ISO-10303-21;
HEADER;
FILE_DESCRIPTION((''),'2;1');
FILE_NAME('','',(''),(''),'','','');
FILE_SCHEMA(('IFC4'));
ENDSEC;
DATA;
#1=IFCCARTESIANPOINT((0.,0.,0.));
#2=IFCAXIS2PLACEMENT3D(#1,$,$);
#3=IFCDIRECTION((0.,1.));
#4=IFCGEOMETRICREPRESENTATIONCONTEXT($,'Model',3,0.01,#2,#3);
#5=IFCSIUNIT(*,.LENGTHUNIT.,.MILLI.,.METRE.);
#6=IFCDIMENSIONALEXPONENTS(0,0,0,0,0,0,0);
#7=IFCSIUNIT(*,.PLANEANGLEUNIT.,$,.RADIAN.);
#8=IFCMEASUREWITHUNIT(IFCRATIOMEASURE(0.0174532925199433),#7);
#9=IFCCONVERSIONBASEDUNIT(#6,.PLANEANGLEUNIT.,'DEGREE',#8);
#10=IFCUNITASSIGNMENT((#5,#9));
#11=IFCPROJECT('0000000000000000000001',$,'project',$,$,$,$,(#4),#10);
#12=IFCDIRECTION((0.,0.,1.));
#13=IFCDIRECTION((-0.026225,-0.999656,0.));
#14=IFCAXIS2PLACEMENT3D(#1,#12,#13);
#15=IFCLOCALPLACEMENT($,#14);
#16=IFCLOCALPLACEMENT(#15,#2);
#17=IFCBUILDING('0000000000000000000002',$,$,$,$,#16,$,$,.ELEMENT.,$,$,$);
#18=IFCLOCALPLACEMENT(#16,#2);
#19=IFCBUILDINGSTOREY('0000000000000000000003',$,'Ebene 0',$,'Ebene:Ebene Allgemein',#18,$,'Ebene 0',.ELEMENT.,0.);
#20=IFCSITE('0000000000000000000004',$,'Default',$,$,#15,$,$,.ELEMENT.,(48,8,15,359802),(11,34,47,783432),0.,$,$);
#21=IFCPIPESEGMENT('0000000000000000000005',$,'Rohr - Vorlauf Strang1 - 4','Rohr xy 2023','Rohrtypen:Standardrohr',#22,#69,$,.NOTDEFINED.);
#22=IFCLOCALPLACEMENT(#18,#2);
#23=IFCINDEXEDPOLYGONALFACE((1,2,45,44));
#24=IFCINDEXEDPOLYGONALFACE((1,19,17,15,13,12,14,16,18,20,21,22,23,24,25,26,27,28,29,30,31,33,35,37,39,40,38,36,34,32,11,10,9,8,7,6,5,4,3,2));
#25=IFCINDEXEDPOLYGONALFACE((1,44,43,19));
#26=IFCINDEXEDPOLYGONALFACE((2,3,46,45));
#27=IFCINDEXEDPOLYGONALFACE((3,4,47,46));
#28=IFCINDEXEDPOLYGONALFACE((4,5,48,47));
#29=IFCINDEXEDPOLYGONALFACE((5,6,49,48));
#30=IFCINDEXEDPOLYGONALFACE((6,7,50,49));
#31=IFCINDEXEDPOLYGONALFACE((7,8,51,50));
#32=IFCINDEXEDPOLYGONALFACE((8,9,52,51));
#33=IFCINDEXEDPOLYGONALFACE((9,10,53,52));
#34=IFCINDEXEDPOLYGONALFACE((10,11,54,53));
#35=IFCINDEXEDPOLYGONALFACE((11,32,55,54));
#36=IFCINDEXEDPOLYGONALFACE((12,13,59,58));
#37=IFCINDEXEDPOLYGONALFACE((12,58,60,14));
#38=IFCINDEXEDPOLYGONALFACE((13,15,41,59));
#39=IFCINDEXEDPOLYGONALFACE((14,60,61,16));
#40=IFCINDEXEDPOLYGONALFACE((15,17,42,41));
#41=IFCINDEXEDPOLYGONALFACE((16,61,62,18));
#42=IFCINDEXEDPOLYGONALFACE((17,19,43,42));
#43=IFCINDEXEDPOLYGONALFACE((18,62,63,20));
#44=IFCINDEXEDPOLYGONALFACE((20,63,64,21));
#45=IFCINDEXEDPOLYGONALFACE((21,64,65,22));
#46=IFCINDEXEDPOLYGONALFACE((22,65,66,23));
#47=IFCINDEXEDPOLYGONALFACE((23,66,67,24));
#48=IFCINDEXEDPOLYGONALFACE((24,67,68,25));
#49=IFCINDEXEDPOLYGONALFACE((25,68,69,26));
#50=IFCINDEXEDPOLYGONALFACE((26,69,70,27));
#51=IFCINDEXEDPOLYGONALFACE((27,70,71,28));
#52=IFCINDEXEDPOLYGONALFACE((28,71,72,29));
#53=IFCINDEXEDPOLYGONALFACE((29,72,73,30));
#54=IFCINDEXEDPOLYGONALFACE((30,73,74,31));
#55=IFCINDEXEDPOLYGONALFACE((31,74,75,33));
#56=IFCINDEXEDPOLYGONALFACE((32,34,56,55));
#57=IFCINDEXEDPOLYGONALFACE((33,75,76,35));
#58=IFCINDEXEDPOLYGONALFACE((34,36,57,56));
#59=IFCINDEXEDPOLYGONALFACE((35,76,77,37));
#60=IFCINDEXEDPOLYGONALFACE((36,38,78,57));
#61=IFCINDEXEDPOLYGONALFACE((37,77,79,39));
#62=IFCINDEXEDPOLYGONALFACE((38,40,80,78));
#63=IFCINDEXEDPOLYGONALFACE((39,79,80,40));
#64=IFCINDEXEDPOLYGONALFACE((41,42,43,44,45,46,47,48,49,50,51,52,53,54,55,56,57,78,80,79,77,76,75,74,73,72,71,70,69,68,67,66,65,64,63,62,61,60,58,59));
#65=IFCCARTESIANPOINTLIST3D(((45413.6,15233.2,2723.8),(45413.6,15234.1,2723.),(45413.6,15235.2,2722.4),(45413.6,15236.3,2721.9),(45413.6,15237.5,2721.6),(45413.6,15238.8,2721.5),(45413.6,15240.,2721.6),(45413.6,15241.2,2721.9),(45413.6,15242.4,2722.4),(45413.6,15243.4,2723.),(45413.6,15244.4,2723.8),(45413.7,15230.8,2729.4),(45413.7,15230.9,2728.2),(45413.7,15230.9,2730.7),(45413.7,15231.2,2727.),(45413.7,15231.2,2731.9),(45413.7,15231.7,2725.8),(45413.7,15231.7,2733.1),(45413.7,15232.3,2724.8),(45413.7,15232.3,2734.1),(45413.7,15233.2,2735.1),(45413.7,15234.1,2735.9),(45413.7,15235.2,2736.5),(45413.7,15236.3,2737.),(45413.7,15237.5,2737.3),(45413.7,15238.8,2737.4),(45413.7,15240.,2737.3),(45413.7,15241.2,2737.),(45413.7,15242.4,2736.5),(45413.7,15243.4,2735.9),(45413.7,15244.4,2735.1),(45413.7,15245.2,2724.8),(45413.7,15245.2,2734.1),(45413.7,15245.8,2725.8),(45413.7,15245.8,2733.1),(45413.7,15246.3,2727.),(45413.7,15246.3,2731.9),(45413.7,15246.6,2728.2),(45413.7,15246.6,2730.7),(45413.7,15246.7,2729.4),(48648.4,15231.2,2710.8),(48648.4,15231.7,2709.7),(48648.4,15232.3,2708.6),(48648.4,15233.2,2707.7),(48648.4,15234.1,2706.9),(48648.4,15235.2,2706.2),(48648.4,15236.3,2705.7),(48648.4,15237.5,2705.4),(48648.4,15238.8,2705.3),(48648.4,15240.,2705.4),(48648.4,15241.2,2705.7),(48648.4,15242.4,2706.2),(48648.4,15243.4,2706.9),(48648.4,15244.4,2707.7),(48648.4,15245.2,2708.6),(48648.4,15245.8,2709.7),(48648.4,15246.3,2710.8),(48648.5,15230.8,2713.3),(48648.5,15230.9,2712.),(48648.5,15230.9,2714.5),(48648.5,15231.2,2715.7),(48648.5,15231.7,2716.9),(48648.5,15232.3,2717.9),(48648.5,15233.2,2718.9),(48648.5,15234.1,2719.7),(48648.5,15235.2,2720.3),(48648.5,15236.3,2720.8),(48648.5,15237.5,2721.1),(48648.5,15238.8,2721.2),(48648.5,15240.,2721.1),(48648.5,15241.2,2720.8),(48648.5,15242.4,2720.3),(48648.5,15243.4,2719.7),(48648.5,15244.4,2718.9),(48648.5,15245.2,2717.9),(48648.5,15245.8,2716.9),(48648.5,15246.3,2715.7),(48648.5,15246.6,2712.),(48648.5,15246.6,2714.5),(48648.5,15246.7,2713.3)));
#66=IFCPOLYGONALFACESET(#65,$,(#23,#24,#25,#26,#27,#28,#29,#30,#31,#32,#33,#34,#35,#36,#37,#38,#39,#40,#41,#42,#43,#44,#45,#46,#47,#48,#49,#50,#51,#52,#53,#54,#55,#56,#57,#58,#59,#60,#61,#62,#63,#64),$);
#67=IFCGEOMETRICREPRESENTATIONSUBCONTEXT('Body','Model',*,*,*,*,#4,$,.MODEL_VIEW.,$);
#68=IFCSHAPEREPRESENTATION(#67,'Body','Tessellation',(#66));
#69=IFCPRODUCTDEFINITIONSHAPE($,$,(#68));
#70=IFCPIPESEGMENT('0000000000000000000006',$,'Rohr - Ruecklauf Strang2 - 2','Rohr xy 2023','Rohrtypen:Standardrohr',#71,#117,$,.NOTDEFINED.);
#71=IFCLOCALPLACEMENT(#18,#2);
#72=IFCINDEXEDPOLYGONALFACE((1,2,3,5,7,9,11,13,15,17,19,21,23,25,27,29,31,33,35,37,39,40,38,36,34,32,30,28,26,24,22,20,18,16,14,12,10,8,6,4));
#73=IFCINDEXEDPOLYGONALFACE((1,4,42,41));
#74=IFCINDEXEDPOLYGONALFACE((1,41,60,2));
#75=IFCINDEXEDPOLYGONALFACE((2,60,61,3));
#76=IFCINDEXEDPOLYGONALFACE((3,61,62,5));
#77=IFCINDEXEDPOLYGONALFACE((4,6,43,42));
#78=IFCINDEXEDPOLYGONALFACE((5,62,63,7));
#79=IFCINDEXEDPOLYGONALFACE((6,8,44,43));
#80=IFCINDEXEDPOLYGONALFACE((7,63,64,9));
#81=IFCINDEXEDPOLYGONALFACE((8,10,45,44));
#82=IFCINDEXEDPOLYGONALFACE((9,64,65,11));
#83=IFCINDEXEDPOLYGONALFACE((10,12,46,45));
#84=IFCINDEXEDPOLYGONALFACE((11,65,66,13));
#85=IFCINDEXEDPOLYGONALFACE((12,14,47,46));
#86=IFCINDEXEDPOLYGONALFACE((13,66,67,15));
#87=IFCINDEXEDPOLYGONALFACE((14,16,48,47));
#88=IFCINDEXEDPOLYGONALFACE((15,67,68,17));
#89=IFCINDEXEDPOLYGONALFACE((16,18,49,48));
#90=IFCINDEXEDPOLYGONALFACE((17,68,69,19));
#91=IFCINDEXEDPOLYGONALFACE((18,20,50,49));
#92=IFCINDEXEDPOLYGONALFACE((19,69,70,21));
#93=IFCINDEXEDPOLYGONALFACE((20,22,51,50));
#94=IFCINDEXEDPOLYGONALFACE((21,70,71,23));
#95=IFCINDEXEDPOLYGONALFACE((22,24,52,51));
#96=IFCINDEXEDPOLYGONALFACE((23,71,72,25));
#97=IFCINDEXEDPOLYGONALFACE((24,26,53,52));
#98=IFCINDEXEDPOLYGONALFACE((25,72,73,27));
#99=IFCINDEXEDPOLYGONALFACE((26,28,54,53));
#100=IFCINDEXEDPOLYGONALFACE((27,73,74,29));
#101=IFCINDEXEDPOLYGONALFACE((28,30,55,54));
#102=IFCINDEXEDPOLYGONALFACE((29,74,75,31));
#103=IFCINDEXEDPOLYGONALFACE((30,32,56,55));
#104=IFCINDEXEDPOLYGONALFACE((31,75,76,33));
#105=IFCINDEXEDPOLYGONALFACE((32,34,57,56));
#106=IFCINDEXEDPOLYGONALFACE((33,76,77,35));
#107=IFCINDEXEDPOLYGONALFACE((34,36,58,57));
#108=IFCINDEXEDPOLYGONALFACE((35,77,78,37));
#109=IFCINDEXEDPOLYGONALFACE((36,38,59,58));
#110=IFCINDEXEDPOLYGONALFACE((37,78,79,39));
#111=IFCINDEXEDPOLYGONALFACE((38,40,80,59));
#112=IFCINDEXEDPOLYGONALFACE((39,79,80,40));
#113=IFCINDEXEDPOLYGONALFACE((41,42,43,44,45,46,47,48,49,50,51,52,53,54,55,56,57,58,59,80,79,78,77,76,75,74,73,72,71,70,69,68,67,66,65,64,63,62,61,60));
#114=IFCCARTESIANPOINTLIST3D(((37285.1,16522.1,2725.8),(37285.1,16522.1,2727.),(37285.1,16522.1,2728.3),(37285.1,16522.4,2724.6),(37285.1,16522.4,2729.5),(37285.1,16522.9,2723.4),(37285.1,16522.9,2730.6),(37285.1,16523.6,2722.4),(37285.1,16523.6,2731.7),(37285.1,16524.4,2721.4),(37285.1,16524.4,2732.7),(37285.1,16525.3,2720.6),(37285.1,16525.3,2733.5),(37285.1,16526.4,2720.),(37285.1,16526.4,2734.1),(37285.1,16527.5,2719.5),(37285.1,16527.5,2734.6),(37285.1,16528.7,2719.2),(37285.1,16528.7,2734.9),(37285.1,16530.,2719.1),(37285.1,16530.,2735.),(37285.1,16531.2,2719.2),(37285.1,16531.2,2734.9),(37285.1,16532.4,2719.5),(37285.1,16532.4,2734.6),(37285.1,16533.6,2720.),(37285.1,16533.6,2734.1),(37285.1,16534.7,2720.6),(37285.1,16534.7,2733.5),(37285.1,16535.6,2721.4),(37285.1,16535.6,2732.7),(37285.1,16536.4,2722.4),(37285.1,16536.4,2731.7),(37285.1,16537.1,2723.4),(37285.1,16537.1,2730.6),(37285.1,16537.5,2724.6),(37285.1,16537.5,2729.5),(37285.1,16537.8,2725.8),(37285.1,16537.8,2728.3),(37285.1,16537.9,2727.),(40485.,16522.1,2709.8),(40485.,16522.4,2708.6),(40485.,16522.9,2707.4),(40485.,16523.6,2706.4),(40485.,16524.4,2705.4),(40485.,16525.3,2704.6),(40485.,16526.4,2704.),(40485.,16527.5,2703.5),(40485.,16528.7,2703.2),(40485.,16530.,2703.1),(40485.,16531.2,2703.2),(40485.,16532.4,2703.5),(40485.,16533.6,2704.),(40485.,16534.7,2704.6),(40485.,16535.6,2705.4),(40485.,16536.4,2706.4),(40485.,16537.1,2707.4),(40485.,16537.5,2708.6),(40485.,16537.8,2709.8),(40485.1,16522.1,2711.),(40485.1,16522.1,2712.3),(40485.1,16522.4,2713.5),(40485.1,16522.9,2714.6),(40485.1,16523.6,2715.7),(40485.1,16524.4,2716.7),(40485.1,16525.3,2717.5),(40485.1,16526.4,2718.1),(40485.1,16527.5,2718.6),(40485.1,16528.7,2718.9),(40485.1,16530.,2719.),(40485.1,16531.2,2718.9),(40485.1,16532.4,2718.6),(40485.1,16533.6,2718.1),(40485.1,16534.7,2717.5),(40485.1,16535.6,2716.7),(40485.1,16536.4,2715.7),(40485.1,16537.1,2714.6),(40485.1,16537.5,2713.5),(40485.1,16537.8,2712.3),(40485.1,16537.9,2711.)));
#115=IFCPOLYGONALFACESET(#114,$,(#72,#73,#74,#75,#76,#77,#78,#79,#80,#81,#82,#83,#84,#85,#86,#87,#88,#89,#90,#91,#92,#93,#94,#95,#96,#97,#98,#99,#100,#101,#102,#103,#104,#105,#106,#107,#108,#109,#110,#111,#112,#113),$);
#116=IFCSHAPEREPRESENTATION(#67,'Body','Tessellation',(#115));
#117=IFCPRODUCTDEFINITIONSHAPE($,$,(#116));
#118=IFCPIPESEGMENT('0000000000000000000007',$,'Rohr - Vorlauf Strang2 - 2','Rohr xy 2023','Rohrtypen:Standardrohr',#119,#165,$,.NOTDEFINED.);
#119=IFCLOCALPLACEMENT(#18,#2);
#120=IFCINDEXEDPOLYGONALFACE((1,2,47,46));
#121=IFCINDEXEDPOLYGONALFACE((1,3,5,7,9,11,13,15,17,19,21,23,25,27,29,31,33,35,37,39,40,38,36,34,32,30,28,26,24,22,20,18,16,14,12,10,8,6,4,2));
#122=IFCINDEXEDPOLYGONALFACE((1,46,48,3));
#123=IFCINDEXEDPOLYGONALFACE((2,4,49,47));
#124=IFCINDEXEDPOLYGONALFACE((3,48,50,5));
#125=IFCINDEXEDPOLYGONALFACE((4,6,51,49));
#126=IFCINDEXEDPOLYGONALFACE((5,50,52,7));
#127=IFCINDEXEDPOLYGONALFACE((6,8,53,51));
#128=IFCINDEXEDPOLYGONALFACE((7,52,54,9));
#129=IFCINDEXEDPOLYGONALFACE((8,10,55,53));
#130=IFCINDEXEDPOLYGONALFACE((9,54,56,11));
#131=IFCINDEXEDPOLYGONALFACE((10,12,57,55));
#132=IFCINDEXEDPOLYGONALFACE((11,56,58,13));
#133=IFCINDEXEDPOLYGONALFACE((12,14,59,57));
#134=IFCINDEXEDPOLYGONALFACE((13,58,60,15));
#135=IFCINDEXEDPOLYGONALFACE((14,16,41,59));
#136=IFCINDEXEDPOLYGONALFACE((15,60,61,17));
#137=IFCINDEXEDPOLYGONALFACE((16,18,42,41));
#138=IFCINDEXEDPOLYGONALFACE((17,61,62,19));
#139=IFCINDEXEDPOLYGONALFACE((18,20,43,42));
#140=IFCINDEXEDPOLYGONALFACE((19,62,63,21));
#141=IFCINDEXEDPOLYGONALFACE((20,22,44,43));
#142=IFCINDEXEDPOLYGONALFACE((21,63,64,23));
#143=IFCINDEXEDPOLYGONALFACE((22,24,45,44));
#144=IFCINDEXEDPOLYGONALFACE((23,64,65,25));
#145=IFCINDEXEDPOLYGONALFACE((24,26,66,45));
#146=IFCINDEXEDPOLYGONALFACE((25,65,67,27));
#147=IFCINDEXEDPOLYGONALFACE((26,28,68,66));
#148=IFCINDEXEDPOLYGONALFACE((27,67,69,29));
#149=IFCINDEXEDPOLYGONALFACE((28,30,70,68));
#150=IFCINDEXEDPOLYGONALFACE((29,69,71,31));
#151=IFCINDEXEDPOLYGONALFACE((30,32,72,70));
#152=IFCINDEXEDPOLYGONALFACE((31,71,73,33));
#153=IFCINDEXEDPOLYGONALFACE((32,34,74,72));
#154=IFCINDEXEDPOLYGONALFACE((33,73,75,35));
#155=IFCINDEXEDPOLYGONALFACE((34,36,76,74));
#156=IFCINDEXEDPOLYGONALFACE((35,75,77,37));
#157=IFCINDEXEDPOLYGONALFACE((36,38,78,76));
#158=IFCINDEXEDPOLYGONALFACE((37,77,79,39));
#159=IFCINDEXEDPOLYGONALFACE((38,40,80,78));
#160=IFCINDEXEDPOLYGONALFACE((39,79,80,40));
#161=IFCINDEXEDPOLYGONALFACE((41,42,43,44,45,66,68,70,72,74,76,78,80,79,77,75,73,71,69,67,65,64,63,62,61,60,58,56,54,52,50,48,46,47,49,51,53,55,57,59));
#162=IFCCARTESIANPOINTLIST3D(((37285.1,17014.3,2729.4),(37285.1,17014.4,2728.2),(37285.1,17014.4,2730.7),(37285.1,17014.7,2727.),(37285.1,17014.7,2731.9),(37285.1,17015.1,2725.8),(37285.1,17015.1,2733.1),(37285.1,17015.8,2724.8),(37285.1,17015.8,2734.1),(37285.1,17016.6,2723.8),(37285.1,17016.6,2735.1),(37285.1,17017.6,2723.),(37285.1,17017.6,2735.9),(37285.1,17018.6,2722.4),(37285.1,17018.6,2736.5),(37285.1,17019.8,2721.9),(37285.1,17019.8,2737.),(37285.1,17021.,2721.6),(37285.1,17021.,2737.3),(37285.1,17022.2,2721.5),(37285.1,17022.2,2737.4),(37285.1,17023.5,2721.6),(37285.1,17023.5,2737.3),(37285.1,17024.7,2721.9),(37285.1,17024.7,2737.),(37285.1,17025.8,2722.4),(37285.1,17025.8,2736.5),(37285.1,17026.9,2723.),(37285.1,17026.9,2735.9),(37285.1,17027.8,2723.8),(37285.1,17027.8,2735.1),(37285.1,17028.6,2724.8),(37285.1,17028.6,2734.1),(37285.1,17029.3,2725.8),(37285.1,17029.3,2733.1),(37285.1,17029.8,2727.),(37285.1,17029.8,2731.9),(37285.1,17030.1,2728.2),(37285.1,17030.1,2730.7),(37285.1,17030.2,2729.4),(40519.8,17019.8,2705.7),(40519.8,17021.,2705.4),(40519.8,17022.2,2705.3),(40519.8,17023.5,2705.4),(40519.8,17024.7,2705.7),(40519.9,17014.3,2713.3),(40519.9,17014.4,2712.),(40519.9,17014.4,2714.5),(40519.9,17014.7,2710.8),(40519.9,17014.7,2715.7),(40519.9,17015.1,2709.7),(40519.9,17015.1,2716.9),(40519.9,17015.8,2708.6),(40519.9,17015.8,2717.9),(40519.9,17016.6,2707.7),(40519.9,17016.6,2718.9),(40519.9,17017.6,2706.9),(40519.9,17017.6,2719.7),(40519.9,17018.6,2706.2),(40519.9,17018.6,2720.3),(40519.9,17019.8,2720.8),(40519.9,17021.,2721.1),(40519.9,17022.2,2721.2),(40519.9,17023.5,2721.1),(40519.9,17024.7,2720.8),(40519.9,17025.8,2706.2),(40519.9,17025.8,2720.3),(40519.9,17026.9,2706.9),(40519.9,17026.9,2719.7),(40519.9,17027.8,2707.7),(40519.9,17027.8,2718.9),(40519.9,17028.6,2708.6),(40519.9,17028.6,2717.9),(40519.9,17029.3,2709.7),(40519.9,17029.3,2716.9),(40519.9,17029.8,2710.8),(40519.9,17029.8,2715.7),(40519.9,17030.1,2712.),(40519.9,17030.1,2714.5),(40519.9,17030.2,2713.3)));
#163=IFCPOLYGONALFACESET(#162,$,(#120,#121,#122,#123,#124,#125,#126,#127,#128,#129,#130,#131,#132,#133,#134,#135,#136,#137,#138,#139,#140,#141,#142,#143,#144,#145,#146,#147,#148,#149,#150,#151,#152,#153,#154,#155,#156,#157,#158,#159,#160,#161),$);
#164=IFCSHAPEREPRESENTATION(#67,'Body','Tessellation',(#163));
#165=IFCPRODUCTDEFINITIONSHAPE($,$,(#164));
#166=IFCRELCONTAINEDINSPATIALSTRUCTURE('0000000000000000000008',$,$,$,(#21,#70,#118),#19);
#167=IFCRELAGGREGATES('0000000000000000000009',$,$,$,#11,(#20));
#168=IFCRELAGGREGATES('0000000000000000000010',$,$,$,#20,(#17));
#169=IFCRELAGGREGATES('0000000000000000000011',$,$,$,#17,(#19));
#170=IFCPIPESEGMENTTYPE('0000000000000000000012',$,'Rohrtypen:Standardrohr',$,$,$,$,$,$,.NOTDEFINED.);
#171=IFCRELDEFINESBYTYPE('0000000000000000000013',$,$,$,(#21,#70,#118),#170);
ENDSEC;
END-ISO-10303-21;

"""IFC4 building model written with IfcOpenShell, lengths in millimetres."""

from ifc_helpers import new_model, entity, si_unit, converted_unit, direction, frame, origin, place, context, subcontext, project, spatial, indexed_curve, outline, extrude, type_object, element, save


model = new_model("IFC4")

# Units and contexts
model_context = context("Model", 3, precision=0.01, world=origin(), true_north=direction((0.0, 1.0)))
body_context = subcontext(model_context, "Body", "Model", "MODEL_VIEW")
ifc_project = project(units=[si_unit("LENGTHUNIT", "METRE", prefix="MILLI"), converted_unit("PLANEANGLEUNIT", "DEGREE", entity("IfcRatioMeasure", 0.0174532925199433), si_unit("PLANEANGLEUNIT", "RADIAN"), dimensions=[0, 0, 0, 0, 0, 0, 0])], contexts=[model_context])

# Site, building, storey
site_placement = place(None, frame((0.0, 0.0, 0.0), z_axis=(0.0, 0.0, 1.0), x_axis=(-0.026225, -0.999656, 0.0)))
site = spatial("IfcSite", under=ifc_project, at=site_placement, Name="Default", CompositionType="ELEMENT", RefLatitude=(48, 8, 15, 359802), RefLongitude=(11, 34, 47, 783432), RefElevation=0.0)
building_placement = place(site_placement, origin())
building = spatial("IfcBuilding", under=site, at=building_placement, CompositionType="ELEMENT")
storey_placement = place(building_placement, origin())
storey = spatial("IfcBuildingStorey", under=building, at=storey_placement, Name="Ebene 0", ObjectType="Ebene:Ebene Allgemein", LongName="Ebene 0", CompositionType="ELEMENT", Elevation=0.0)

# Pipe segments
pipe_segment_type = type_object("IfcPipeSegmentType", Name="Rohrtypen:Standardrohr", PredefinedType="NOTDEFINED")
pipe_segment_1_placement = place(storey_placement, origin())
element("IfcPipeSegment", 1, at=pipe_segment_1_placement, inside=storey, type_object=pipe_segment_type, Name="Rohr - Vorlauf Strang1 - 4", Description="Rohr xy 2023", ObjectType="Rohrtypen:Standardrohr", PredefinedType="NOTDEFINED", context=body_context, shape_type="SweptSolid", body=[
    extrude(outline(indexed_curve([(7.9, 0.0), (7.8, 1.2), (7.6, 2.5), (7.1, 3.6), (6.4, 4.7), (5.6, 5.6), (4.7, 6.4), (3.6, 7.1), (2.5, 7.6), (1.2, 7.8), (0.0, 7.9), (-1.2, 7.8), (-2.5, 7.6), (-3.6, 7.1), (-4.7, 6.4), (-5.6, 5.6), (-6.4, 4.7), (-7.1, 3.6), (-7.6, 2.5), (-7.8, 1.2), (-7.9, 0.0), (-7.8, -1.2), (-7.6, -2.5), (-7.1, -3.6), (-6.4, -4.7), (-5.6, -5.6), (-4.7, -6.4), (-3.6, -7.1), (-2.5, -7.6), (-1.2, -7.8), (0.0, -7.9), (1.2, -7.8), (2.5, -7.6), (3.6, -7.1), (4.7, -6.4), (5.6, -5.6), (6.4, -4.7), (7.1, -3.6), (7.6, -2.5), (7.8, -1.2), (7.9, 0.0)], self_intersect=False)), frame((48648.5, 15238.8, 2713.3), z_axis=(-0.999988, 0.0, 0.005), x_axis=(0.0, 1.0, 0.0)), (0.0, 0.0, 1.0), 3234.8),
])
pipe_segment_2_placement = place(storey_placement, origin())
element("IfcPipeSegment", 2, at=pipe_segment_2_placement, inside=storey, type_object=pipe_segment_type, Name="Rohr - Ruecklauf Strang2 - 2", Description="Rohr xy 2023", ObjectType="Rohrtypen:Standardrohr", PredefinedType="NOTDEFINED", context=body_context, shape_type="SweptSolid", body=[
    extrude(outline(indexed_curve([(7.9, 0.0), (7.8, 1.2), (7.6, 2.5), (7.1, 3.6), (6.4, 4.7), (5.6, 5.6), (4.7, 6.4), (3.6, 7.1), (2.5, 7.6), (1.2, 7.8), (0.0, 7.9), (-1.2, 7.8), (-2.5, 7.6), (-3.6, 7.1), (-4.7, 6.4), (-5.6, 5.6), (-6.4, 4.7), (-7.1, 3.6), (-7.6, 2.5), (-7.8, 1.2), (-7.9, 0.0), (-7.8, -1.2), (-7.6, -2.5), (-7.1, -3.6), (-6.4, -4.7), (-5.6, -5.6), (-4.7, -6.4), (-3.6, -7.1), (-2.5, -7.6), (-1.2, -7.8), (0.0, -7.9), (1.2, -7.8), (2.5, -7.6), (3.6, -7.1), (4.7, -6.4), (5.6, -5.6), (6.4, -4.7), (7.1, -3.6), (7.6, -2.5), (7.8, -1.2), (7.9, 0.0)], self_intersect=False)), frame((40485.1, 16530.0, 2711.0), z_axis=(-0.999988, 0.0, 0.005), x_axis=(0.0, 1.0, 0.0)), (0.0, 0.0, 1.0), 3200.0),
])
pipe_segment_3_placement = place(storey_placement, origin())
element("IfcPipeSegment", 3, at=pipe_segment_3_placement, inside=storey, type_object=pipe_segment_type, Name="Rohr - Vorlauf Strang2 - 2", Description="Rohr xy 2023", ObjectType="Rohrtypen:Standardrohr", PredefinedType="NOTDEFINED", context=body_context, shape_type="SweptSolid", body=[
    extrude(outline(indexed_curve([(7.9, 0.0), (7.8, 1.2), (7.6, 2.5), (7.1, 3.6), (6.4, 4.7), (5.6, 5.6), (4.7, 6.4), (3.6, 7.1), (2.5, 7.6), (1.2, 7.8), (0.0, 7.9), (-1.2, 7.8), (-2.5, 7.6), (-3.6, 7.1), (-4.7, 6.4), (-5.6, 5.6), (-6.4, 4.7), (-7.1, 3.6), (-7.6, 2.5), (-7.8, 1.2), (-7.9, 0.0), (-7.8, -1.2), (-7.6, -2.5), (-7.1, -3.6), (-6.4, -4.7), (-5.6, -5.6), (-4.7, -6.4), (-3.6, -7.1), (-2.5, -7.6), (-1.2, -7.8), (0.0, -7.9), (1.2, -7.8), (2.5, -7.6), (3.6, -7.1), (4.7, -6.4), (5.6, -5.6), (6.4, -4.7), (7.1, -3.6), (7.6, -2.5), (7.8, -1.2), (7.9, 0.0)], self_intersect=False)), frame((40519.9, 17022.2, 2713.3), z_axis=(-0.999988, 0.0, 0.005), x_axis=(0.0, 1.0, 0.0)), (0.0, 0.0, 1.0), 3234.8),
])

save(model, "model.ifc")
